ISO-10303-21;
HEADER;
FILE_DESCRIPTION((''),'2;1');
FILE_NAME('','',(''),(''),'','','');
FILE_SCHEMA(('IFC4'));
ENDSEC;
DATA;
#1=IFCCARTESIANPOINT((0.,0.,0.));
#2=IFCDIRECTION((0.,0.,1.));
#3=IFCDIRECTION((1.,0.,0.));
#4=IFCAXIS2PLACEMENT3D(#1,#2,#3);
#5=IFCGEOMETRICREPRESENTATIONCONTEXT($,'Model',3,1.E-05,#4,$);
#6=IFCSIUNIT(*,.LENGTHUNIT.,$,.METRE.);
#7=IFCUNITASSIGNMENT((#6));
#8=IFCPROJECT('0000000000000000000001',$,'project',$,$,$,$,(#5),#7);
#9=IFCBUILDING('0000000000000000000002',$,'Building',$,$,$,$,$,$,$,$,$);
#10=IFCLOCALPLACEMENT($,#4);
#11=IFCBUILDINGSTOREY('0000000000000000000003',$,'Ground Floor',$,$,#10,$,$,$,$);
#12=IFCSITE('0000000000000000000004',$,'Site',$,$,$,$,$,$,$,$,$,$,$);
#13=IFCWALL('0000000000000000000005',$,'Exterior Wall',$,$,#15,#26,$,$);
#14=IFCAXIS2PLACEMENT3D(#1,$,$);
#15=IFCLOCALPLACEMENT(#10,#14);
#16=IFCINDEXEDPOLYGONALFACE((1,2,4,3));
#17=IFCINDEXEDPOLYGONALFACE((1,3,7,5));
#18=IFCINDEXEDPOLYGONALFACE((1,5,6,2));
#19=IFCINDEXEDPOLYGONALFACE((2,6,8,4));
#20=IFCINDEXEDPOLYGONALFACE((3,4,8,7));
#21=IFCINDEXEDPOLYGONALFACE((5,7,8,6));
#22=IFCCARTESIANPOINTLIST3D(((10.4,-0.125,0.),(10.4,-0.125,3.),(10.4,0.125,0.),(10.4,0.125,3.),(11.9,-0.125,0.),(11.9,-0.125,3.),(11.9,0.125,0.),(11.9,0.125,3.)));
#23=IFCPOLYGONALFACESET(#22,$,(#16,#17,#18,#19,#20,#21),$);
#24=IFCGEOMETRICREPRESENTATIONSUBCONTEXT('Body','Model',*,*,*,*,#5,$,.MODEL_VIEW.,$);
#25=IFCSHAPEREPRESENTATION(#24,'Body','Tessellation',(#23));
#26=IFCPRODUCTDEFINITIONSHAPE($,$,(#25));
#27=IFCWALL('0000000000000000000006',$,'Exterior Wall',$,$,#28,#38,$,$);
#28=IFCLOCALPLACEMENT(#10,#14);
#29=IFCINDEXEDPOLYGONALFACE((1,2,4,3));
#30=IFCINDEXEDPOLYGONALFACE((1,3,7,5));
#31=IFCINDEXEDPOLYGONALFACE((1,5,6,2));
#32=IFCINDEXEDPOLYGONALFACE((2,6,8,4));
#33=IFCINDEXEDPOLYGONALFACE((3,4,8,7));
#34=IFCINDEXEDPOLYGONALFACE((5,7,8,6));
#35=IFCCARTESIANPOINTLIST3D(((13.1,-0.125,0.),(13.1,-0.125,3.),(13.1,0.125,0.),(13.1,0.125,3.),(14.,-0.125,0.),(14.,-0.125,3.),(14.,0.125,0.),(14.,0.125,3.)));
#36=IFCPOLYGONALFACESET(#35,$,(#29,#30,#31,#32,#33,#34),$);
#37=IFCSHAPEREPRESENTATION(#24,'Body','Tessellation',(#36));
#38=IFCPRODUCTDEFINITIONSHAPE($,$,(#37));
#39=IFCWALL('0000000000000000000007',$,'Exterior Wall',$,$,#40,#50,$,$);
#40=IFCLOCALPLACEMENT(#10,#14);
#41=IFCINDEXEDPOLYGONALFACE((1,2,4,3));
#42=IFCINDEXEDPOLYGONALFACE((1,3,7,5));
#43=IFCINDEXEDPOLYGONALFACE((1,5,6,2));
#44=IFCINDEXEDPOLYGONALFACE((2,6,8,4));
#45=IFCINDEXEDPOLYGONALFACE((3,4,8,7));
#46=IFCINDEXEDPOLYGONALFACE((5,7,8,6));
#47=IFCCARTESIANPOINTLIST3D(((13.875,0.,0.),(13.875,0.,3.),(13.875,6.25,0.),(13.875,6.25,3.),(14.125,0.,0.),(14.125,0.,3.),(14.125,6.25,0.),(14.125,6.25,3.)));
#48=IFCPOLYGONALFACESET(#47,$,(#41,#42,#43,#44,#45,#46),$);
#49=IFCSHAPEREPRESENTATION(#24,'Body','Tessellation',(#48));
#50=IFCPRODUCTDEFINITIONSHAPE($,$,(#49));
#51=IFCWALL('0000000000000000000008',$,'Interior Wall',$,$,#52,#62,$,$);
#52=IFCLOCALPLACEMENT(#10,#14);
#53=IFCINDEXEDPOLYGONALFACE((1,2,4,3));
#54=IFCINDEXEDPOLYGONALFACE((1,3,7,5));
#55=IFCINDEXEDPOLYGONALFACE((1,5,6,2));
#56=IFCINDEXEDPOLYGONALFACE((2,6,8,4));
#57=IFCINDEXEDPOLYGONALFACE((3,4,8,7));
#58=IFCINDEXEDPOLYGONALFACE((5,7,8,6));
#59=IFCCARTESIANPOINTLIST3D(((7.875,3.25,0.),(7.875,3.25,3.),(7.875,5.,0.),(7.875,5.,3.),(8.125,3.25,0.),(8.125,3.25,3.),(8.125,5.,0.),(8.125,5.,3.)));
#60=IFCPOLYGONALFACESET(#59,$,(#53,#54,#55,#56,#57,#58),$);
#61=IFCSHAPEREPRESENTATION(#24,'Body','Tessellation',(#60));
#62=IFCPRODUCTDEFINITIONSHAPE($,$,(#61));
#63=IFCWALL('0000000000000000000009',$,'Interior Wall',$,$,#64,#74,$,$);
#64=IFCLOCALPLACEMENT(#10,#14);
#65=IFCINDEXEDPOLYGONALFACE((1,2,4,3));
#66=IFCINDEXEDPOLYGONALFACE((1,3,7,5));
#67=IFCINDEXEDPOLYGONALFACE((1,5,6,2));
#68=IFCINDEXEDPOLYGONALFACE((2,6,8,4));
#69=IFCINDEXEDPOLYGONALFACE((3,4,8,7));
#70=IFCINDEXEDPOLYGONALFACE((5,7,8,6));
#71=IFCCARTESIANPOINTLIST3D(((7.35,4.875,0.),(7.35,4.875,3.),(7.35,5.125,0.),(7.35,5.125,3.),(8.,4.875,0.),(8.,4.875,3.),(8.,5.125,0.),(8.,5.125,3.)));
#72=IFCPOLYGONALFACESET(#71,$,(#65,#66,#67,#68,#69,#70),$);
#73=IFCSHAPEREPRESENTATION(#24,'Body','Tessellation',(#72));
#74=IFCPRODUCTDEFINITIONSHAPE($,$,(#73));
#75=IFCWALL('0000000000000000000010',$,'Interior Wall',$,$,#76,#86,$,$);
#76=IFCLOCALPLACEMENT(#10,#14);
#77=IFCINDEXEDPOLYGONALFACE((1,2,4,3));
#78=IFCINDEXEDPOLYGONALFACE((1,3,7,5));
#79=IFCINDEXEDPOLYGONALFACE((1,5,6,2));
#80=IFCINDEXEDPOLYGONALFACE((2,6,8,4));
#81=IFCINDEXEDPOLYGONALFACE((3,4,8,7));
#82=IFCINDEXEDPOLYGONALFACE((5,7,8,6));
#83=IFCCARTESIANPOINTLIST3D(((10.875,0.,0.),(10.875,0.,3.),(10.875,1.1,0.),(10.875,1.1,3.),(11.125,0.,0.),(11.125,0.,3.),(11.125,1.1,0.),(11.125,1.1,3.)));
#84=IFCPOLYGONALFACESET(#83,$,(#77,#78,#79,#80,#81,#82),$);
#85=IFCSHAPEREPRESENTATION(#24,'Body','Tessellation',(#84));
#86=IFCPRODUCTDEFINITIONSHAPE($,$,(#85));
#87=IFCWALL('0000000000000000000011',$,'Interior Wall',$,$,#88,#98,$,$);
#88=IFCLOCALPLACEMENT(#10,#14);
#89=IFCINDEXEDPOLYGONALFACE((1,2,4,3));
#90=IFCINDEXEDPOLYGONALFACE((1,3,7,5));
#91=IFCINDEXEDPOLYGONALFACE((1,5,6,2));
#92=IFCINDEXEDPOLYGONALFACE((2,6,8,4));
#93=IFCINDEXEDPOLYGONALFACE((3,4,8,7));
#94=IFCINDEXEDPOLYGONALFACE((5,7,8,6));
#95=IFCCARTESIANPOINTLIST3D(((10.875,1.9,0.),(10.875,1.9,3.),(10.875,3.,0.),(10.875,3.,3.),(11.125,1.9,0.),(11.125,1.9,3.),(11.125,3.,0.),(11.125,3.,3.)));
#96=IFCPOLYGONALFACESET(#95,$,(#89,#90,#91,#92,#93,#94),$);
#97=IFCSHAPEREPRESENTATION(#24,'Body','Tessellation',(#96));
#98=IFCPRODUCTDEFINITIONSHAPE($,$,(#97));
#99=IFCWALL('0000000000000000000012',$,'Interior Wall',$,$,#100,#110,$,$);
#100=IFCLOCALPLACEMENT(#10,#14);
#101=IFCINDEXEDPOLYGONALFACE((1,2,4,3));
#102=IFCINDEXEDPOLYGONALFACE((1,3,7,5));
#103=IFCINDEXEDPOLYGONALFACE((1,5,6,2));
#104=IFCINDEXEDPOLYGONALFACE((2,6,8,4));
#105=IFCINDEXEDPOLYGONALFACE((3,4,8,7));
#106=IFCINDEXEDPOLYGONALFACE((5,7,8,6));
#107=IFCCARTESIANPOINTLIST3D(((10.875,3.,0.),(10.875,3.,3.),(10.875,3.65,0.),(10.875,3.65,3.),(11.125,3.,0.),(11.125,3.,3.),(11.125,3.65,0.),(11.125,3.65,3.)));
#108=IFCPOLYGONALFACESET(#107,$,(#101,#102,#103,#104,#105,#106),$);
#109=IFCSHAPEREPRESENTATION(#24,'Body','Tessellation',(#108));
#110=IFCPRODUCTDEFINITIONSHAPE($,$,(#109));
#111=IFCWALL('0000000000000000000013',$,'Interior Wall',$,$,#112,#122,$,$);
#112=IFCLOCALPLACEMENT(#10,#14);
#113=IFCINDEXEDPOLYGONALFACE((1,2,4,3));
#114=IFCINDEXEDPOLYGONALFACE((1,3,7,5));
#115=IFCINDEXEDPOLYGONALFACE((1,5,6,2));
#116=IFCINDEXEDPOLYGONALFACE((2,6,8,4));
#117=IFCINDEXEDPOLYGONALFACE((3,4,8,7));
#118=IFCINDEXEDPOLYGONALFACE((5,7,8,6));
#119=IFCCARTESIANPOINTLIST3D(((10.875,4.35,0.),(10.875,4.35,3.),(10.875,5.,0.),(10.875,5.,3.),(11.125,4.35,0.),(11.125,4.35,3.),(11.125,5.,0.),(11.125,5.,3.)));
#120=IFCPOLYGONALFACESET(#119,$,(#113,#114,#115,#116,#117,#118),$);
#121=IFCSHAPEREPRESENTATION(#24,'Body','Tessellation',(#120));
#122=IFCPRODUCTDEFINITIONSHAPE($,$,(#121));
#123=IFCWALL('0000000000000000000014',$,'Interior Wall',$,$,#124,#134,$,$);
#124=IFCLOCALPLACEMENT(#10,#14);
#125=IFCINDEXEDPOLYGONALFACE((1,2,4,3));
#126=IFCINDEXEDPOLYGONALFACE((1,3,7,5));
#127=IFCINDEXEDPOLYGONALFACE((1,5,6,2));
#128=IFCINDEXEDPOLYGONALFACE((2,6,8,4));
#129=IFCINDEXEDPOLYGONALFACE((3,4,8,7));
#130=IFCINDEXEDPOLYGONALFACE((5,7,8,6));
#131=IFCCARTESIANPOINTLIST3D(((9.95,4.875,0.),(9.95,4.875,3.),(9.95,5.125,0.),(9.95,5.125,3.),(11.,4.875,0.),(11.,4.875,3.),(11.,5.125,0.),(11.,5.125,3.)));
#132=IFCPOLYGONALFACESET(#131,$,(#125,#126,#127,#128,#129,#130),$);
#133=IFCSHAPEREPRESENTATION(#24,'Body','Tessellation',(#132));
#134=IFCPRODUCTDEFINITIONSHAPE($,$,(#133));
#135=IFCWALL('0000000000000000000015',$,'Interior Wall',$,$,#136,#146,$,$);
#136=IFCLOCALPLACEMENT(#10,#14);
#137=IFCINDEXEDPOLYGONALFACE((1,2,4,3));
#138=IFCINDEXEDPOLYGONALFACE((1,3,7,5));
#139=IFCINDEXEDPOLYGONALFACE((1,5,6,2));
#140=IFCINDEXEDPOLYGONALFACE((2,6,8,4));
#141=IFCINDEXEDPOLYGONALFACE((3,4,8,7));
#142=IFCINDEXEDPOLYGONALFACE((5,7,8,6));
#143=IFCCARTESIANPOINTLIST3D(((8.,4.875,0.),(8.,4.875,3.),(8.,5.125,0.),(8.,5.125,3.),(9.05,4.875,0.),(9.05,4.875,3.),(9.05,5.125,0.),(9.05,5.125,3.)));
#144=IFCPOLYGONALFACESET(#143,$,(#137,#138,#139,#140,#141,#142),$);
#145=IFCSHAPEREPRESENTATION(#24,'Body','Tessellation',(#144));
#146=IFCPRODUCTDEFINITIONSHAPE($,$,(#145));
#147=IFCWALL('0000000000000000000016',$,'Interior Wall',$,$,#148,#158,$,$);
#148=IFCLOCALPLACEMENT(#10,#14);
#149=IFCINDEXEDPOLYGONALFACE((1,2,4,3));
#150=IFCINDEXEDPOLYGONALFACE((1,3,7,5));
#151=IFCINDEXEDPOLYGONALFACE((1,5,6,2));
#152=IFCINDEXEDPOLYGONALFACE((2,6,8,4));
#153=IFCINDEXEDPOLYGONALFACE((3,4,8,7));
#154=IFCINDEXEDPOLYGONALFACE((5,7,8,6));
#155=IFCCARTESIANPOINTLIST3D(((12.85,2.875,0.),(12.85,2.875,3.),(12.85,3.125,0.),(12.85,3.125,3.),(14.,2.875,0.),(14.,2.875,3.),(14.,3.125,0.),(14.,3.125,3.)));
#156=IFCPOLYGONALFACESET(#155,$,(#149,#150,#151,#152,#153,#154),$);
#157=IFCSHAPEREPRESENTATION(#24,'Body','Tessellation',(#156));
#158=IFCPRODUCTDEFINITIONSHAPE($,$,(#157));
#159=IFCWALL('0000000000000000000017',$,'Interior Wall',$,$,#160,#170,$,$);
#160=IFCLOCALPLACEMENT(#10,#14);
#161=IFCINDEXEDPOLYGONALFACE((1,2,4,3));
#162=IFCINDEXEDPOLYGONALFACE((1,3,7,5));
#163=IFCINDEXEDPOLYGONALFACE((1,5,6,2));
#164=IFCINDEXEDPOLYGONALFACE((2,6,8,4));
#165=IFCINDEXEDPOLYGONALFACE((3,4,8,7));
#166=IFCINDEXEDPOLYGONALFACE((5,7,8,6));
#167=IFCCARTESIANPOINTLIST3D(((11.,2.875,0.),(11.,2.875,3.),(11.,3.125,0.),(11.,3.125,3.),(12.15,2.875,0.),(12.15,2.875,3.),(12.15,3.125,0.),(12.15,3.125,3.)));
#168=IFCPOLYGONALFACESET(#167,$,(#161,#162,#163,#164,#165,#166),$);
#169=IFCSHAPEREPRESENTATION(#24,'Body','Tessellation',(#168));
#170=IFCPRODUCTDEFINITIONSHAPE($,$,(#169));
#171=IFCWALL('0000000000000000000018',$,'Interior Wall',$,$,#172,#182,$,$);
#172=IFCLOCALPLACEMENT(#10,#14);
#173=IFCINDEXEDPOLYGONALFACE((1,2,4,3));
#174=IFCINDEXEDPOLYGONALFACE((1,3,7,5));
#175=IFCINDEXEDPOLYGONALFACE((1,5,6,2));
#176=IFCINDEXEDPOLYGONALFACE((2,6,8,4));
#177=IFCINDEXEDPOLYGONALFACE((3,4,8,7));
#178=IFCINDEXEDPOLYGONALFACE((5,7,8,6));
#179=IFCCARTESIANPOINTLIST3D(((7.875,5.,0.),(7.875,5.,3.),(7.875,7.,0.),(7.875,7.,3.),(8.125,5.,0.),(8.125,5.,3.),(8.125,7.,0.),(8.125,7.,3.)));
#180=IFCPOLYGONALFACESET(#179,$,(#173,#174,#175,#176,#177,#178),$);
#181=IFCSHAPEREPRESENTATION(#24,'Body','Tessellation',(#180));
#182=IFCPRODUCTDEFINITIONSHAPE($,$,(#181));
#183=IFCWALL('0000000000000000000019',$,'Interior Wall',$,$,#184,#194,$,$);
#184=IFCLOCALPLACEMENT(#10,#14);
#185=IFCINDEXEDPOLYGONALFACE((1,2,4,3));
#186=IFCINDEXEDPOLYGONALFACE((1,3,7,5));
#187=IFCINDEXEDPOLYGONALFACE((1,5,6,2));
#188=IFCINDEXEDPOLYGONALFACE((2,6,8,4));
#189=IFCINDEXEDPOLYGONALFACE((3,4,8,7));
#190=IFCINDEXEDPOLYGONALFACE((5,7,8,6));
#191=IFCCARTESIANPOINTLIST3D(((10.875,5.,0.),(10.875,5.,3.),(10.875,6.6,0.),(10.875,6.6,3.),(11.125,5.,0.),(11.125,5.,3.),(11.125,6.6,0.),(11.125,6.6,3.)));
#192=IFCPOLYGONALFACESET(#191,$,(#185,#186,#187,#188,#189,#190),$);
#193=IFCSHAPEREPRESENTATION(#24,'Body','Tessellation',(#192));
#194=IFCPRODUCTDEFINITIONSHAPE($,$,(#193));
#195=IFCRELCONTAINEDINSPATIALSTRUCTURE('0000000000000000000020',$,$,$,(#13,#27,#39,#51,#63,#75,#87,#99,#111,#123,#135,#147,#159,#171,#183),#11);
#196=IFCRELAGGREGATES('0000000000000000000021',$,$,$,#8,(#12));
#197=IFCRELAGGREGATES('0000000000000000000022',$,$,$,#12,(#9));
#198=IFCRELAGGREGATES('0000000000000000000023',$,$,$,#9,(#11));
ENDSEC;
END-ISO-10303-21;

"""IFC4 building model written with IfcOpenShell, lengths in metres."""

from ifc_helpers import new_model, si_unit, frame, origin_with_axes, place, context, subcontext, project, spatial, indexed_curve, outline, extrude, element, save


model = new_model("IFC4")

# Units and contexts
model_context = context("Model", 3, precision=1e-05, world=origin_with_axes())
body_context = subcontext(model_context, "Body", "Model", "MODEL_VIEW")
ifc_project = project(units=[si_unit("LENGTHUNIT", "METRE")], contexts=[model_context])

# Site, building, storey
site = spatial("IfcSite", under=ifc_project, Name="Site")
building = spatial("IfcBuilding", under=site, Name="Building")
storey_placement = place(None, origin_with_axes())
storey = spatial("IfcBuildingStorey", under=building, at=storey_placement, Name="Ground Floor")

# Walls
wall_1_placement = place(storey_placement, frame((10.4, 0.0, 0.0), z_axis=(0.0, 0.0, 1.0), x_axis=(1.0, 0.0, 0.0)))
element("IfcWall", 1, at=wall_1_placement, inside=storey, Name="Exterior Wall", context=body_context, shape_type="SweptSolid", body=[
    extrude(outline(indexed_curve([(0.0, 0.0), (0.0, 0.25), (1.5, 0.25), (1.5, 0.0), (0.0, 0.0)], self_intersect=False)), frame((0.0, -0.125, 0.0), z_axis=(0.0, 0.0, 1.0), x_axis=(1.0, 0.0, 0.0)), (0.0, 0.0, 1.0), 3.0),
])
wall_2_placement = place(storey_placement, frame((13.1, 0.0, 0.0), z_axis=(0.0, 0.0, 1.0), x_axis=(1.0, 0.0, 0.0)))
element("IfcWall", 2, at=wall_2_placement, inside=storey, Name="Exterior Wall", context=body_context, shape_type="SweptSolid", body=[
    extrude(outline(indexed_curve([(0.0, 0.0), (0.0, 0.25), (0.9, 0.25), (0.9, 0.0), (0.0, 0.0)], self_intersect=False)), frame((0.0, -0.125, 0.0), z_axis=(0.0, 0.0, 1.0), x_axis=(1.0, 0.0, 0.0)), (0.0, 0.0, 1.0), 3.0),
])
wall_3_placement = place(storey_placement, frame((14.0, 0.0, 0.0), z_axis=(0.0, 0.0, 1.0), x_axis=(0.0, 1.0, 0.0)))
element("IfcWall", 3, at=wall_3_placement, inside=storey, Name="Exterior Wall", context=body_context, shape_type="SweptSolid", body=[
    extrude(outline(indexed_curve([(0.0, 0.0), (0.0, 0.25), (6.25, 0.25), (6.25, 0.0), (0.0, 0.0)], self_intersect=False)), frame((0.0, -0.125, 0.0), z_axis=(0.0, 0.0, 1.0), x_axis=(1.0, 0.0, 0.0)), (0.0, 0.0, 1.0), 3.0),
])
wall_4_placement = place(storey_placement, frame((8.0, 3.25, 0.0), z_axis=(0.0, 0.0, 1.0), x_axis=(0.0, 1.0, 0.0)))
element("IfcWall", 4, at=wall_4_placement, inside=storey, Name="Interior Wall", context=body_context, shape_type="SweptSolid", body=[
    extrude(outline(indexed_curve([(0.0, 0.0), (0.0, 0.25), (1.75, 0.25), (1.75, 0.0), (0.0, 0.0)], self_intersect=False)), frame((0.0, -0.125, 0.0), z_axis=(0.0, 0.0, 1.0), x_axis=(1.0, 0.0, 0.0)), (0.0, 0.0, 1.0), 3.0),
])
wall_5_placement = place(storey_placement, frame((8.0, 5.0, 0.0), z_axis=(0.0, 0.0, 1.0), x_axis=(-1.0, 0.0, 0.0)))
element("IfcWall", 5, at=wall_5_placement, inside=storey, Name="Interior Wall", context=body_context, shape_type="SweptSolid", body=[
    extrude(outline(indexed_curve([(0.0, 0.0), (0.0, 0.25), (0.65, 0.25), (0.65, 0.0), (0.0, 0.0)], self_intersect=False)), frame((0.0, -0.125, 0.0), z_axis=(0.0, 0.0, 1.0), x_axis=(1.0, 0.0, 0.0)), (0.0, 0.0, 1.0), 3.0),
])
for number, where, z_axis, x_axis, name in (
    (6, (11.0, 0.0, 0.0), (0.0, 0.0, 1.0), (0.0, 1.0, 0.0), "Interior Wall"),
    (7, (11.0, 1.9, 0.0), (0.0, 0.0, 1.0), (0.0, 1.0, 0.0), "Interior Wall"),
):
    element("IfcWall", number, at=place(storey_placement, frame(where, z_axis=z_axis, x_axis=x_axis)), inside=storey, Name=name, context=body_context, shape_type="SweptSolid", body=[
        extrude(outline(indexed_curve([(0.0, 0.0), (0.0, 0.25), (1.1, 0.25), (1.1, 0.0), (0.0, 0.0)], self_intersect=False)), frame((0.0, -0.125, 0.0), z_axis=(0.0, 0.0, 1.0), x_axis=(1.0, 0.0, 0.0)), (0.0, 0.0, 1.0), 3.0),
    ])
wall_6_placement = place(storey_placement, frame((11.0, 3.0, 0.0), z_axis=(0.0, 0.0, 1.0), x_axis=(0.0, 1.0, 0.0)))
element("IfcWall", 8, at=wall_6_placement, inside=storey, Name="Interior Wall", context=body_context, shape_type="SweptSolid", body=[
    extrude(outline(indexed_curve([(0.0, 0.0), (0.0, 0.25), (0.65, 0.25), (0.65, 0.0), (0.0, 0.0)], self_intersect=False)), frame((0.0, -0.125, 0.0), z_axis=(0.0, 0.0, 1.0), x_axis=(1.0, 0.0, 0.0)), (0.0, 0.0, 1.0), 3.0),
])
wall_7_placement = place(storey_placement, frame((11.0, 4.35, 0.0), z_axis=(0.0, 0.0, 1.0), x_axis=(0.0, 1.0, 0.0)))
element("IfcWall", 9, at=wall_7_placement, inside=storey, Name="Interior Wall", context=body_context, shape_type="SweptSolid", body=[
    extrude(outline(indexed_curve([(0.0, 0.0), (0.0, 0.25), (0.65, 0.25), (0.65, 0.0), (0.0, 0.0)], self_intersect=False)), frame((0.0, -0.125, 0.0), z_axis=(0.0, 0.0, 1.0), x_axis=(1.0, 0.0, 0.0)), (0.0, 0.0, 1.0), 3.0),
])
for number, where, z_axis, x_axis, name in (
    (10, (11.0, 5.0, 0.0), (0.0, 0.0, 1.0), (-1.0, 0.0, 0.0), "Interior Wall"),
    (11, (9.05, 5.0, 0.0), (0.0, 0.0, 1.0), (-1.0, 0.0, 0.0), "Interior Wall"),
):
    element("IfcWall", number, at=place(storey_placement, frame(where, z_axis=z_axis, x_axis=x_axis)), inside=storey, Name=name, context=body_context, shape_type="SweptSolid", body=[
        extrude(outline(indexed_curve([(0.0, 0.0), (0.0, 0.25), (1.05, 0.25), (1.05, 0.0), (0.0, 0.0)], self_intersect=False)), frame((0.0, -0.125, 0.0), z_axis=(0.0, 0.0, 1.0), x_axis=(1.0, 0.0, 0.0)), (0.0, 0.0, 1.0), 3.0),
    ])
for number, where, z_axis, x_axis, name in (
    (12, (14.0, 3.0, 0.0), (0.0, 0.0, 1.0), (-1.0, 0.0, 0.0), "Interior Wall"),
    (13, (12.15, 3.0, 0.0), (0.0, 0.0, 1.0), (-1.0, 0.0, 0.0), "Interior Wall"),
):
    element("IfcWall", number, at=place(storey_placement, frame(where, z_axis=z_axis, x_axis=x_axis)), inside=storey, Name=name, context=body_context, shape_type="SweptSolid", body=[
        extrude(outline(indexed_curve([(0.0, 0.0), (0.0, 0.25), (1.15, 0.25), (1.15, 0.0), (0.0, 0.0)], self_intersect=False)), frame((0.0, -0.125, 0.0), z_axis=(0.0, 0.0, 1.0), x_axis=(1.0, 0.0, 0.0)), (0.0, 0.0, 1.0), 3.0),
    ])
wall_8_placement = place(storey_placement, frame((8.0, 5.0, 0.0), z_axis=(0.0, 0.0, 1.0), x_axis=(0.0, 1.0, 0.0)))
element("IfcWall", 14, at=wall_8_placement, inside=storey, Name="Interior Wall", context=body_context, shape_type="SweptSolid", body=[
    extrude(outline(indexed_curve([(0.0, 0.0), (0.0, 0.25), (2.0, 0.25), (2.0, 0.0), (0.0, 0.0)], self_intersect=False)), frame((0.0, -0.125, 0.0), z_axis=(0.0, 0.0, 1.0), x_axis=(1.0, 0.0, 0.0)), (0.0, 0.0, 1.0), 3.0),
])
wall_9_placement = place(storey_placement, frame((11.0, 5.0, 0.0), z_axis=(0.0, 0.0, 1.0), x_axis=(0.0, 1.0, 0.0)))
element("IfcWall", 15, at=wall_9_placement, inside=storey, Name="Interior Wall", context=body_context, shape_type="SweptSolid", body=[
    extrude(outline(indexed_curve([(0.0, 0.0), (0.0, 0.25), (1.6, 0.25), (1.6, 0.0), (0.0, 0.0)], self_intersect=False)), frame((0.0, -0.125, 0.0), z_axis=(0.0, 0.0, 1.0), x_axis=(1.0, 0.0, 0.0)), (0.0, 0.0, 1.0), 3.0),
])

save(model, "model.ifc")
